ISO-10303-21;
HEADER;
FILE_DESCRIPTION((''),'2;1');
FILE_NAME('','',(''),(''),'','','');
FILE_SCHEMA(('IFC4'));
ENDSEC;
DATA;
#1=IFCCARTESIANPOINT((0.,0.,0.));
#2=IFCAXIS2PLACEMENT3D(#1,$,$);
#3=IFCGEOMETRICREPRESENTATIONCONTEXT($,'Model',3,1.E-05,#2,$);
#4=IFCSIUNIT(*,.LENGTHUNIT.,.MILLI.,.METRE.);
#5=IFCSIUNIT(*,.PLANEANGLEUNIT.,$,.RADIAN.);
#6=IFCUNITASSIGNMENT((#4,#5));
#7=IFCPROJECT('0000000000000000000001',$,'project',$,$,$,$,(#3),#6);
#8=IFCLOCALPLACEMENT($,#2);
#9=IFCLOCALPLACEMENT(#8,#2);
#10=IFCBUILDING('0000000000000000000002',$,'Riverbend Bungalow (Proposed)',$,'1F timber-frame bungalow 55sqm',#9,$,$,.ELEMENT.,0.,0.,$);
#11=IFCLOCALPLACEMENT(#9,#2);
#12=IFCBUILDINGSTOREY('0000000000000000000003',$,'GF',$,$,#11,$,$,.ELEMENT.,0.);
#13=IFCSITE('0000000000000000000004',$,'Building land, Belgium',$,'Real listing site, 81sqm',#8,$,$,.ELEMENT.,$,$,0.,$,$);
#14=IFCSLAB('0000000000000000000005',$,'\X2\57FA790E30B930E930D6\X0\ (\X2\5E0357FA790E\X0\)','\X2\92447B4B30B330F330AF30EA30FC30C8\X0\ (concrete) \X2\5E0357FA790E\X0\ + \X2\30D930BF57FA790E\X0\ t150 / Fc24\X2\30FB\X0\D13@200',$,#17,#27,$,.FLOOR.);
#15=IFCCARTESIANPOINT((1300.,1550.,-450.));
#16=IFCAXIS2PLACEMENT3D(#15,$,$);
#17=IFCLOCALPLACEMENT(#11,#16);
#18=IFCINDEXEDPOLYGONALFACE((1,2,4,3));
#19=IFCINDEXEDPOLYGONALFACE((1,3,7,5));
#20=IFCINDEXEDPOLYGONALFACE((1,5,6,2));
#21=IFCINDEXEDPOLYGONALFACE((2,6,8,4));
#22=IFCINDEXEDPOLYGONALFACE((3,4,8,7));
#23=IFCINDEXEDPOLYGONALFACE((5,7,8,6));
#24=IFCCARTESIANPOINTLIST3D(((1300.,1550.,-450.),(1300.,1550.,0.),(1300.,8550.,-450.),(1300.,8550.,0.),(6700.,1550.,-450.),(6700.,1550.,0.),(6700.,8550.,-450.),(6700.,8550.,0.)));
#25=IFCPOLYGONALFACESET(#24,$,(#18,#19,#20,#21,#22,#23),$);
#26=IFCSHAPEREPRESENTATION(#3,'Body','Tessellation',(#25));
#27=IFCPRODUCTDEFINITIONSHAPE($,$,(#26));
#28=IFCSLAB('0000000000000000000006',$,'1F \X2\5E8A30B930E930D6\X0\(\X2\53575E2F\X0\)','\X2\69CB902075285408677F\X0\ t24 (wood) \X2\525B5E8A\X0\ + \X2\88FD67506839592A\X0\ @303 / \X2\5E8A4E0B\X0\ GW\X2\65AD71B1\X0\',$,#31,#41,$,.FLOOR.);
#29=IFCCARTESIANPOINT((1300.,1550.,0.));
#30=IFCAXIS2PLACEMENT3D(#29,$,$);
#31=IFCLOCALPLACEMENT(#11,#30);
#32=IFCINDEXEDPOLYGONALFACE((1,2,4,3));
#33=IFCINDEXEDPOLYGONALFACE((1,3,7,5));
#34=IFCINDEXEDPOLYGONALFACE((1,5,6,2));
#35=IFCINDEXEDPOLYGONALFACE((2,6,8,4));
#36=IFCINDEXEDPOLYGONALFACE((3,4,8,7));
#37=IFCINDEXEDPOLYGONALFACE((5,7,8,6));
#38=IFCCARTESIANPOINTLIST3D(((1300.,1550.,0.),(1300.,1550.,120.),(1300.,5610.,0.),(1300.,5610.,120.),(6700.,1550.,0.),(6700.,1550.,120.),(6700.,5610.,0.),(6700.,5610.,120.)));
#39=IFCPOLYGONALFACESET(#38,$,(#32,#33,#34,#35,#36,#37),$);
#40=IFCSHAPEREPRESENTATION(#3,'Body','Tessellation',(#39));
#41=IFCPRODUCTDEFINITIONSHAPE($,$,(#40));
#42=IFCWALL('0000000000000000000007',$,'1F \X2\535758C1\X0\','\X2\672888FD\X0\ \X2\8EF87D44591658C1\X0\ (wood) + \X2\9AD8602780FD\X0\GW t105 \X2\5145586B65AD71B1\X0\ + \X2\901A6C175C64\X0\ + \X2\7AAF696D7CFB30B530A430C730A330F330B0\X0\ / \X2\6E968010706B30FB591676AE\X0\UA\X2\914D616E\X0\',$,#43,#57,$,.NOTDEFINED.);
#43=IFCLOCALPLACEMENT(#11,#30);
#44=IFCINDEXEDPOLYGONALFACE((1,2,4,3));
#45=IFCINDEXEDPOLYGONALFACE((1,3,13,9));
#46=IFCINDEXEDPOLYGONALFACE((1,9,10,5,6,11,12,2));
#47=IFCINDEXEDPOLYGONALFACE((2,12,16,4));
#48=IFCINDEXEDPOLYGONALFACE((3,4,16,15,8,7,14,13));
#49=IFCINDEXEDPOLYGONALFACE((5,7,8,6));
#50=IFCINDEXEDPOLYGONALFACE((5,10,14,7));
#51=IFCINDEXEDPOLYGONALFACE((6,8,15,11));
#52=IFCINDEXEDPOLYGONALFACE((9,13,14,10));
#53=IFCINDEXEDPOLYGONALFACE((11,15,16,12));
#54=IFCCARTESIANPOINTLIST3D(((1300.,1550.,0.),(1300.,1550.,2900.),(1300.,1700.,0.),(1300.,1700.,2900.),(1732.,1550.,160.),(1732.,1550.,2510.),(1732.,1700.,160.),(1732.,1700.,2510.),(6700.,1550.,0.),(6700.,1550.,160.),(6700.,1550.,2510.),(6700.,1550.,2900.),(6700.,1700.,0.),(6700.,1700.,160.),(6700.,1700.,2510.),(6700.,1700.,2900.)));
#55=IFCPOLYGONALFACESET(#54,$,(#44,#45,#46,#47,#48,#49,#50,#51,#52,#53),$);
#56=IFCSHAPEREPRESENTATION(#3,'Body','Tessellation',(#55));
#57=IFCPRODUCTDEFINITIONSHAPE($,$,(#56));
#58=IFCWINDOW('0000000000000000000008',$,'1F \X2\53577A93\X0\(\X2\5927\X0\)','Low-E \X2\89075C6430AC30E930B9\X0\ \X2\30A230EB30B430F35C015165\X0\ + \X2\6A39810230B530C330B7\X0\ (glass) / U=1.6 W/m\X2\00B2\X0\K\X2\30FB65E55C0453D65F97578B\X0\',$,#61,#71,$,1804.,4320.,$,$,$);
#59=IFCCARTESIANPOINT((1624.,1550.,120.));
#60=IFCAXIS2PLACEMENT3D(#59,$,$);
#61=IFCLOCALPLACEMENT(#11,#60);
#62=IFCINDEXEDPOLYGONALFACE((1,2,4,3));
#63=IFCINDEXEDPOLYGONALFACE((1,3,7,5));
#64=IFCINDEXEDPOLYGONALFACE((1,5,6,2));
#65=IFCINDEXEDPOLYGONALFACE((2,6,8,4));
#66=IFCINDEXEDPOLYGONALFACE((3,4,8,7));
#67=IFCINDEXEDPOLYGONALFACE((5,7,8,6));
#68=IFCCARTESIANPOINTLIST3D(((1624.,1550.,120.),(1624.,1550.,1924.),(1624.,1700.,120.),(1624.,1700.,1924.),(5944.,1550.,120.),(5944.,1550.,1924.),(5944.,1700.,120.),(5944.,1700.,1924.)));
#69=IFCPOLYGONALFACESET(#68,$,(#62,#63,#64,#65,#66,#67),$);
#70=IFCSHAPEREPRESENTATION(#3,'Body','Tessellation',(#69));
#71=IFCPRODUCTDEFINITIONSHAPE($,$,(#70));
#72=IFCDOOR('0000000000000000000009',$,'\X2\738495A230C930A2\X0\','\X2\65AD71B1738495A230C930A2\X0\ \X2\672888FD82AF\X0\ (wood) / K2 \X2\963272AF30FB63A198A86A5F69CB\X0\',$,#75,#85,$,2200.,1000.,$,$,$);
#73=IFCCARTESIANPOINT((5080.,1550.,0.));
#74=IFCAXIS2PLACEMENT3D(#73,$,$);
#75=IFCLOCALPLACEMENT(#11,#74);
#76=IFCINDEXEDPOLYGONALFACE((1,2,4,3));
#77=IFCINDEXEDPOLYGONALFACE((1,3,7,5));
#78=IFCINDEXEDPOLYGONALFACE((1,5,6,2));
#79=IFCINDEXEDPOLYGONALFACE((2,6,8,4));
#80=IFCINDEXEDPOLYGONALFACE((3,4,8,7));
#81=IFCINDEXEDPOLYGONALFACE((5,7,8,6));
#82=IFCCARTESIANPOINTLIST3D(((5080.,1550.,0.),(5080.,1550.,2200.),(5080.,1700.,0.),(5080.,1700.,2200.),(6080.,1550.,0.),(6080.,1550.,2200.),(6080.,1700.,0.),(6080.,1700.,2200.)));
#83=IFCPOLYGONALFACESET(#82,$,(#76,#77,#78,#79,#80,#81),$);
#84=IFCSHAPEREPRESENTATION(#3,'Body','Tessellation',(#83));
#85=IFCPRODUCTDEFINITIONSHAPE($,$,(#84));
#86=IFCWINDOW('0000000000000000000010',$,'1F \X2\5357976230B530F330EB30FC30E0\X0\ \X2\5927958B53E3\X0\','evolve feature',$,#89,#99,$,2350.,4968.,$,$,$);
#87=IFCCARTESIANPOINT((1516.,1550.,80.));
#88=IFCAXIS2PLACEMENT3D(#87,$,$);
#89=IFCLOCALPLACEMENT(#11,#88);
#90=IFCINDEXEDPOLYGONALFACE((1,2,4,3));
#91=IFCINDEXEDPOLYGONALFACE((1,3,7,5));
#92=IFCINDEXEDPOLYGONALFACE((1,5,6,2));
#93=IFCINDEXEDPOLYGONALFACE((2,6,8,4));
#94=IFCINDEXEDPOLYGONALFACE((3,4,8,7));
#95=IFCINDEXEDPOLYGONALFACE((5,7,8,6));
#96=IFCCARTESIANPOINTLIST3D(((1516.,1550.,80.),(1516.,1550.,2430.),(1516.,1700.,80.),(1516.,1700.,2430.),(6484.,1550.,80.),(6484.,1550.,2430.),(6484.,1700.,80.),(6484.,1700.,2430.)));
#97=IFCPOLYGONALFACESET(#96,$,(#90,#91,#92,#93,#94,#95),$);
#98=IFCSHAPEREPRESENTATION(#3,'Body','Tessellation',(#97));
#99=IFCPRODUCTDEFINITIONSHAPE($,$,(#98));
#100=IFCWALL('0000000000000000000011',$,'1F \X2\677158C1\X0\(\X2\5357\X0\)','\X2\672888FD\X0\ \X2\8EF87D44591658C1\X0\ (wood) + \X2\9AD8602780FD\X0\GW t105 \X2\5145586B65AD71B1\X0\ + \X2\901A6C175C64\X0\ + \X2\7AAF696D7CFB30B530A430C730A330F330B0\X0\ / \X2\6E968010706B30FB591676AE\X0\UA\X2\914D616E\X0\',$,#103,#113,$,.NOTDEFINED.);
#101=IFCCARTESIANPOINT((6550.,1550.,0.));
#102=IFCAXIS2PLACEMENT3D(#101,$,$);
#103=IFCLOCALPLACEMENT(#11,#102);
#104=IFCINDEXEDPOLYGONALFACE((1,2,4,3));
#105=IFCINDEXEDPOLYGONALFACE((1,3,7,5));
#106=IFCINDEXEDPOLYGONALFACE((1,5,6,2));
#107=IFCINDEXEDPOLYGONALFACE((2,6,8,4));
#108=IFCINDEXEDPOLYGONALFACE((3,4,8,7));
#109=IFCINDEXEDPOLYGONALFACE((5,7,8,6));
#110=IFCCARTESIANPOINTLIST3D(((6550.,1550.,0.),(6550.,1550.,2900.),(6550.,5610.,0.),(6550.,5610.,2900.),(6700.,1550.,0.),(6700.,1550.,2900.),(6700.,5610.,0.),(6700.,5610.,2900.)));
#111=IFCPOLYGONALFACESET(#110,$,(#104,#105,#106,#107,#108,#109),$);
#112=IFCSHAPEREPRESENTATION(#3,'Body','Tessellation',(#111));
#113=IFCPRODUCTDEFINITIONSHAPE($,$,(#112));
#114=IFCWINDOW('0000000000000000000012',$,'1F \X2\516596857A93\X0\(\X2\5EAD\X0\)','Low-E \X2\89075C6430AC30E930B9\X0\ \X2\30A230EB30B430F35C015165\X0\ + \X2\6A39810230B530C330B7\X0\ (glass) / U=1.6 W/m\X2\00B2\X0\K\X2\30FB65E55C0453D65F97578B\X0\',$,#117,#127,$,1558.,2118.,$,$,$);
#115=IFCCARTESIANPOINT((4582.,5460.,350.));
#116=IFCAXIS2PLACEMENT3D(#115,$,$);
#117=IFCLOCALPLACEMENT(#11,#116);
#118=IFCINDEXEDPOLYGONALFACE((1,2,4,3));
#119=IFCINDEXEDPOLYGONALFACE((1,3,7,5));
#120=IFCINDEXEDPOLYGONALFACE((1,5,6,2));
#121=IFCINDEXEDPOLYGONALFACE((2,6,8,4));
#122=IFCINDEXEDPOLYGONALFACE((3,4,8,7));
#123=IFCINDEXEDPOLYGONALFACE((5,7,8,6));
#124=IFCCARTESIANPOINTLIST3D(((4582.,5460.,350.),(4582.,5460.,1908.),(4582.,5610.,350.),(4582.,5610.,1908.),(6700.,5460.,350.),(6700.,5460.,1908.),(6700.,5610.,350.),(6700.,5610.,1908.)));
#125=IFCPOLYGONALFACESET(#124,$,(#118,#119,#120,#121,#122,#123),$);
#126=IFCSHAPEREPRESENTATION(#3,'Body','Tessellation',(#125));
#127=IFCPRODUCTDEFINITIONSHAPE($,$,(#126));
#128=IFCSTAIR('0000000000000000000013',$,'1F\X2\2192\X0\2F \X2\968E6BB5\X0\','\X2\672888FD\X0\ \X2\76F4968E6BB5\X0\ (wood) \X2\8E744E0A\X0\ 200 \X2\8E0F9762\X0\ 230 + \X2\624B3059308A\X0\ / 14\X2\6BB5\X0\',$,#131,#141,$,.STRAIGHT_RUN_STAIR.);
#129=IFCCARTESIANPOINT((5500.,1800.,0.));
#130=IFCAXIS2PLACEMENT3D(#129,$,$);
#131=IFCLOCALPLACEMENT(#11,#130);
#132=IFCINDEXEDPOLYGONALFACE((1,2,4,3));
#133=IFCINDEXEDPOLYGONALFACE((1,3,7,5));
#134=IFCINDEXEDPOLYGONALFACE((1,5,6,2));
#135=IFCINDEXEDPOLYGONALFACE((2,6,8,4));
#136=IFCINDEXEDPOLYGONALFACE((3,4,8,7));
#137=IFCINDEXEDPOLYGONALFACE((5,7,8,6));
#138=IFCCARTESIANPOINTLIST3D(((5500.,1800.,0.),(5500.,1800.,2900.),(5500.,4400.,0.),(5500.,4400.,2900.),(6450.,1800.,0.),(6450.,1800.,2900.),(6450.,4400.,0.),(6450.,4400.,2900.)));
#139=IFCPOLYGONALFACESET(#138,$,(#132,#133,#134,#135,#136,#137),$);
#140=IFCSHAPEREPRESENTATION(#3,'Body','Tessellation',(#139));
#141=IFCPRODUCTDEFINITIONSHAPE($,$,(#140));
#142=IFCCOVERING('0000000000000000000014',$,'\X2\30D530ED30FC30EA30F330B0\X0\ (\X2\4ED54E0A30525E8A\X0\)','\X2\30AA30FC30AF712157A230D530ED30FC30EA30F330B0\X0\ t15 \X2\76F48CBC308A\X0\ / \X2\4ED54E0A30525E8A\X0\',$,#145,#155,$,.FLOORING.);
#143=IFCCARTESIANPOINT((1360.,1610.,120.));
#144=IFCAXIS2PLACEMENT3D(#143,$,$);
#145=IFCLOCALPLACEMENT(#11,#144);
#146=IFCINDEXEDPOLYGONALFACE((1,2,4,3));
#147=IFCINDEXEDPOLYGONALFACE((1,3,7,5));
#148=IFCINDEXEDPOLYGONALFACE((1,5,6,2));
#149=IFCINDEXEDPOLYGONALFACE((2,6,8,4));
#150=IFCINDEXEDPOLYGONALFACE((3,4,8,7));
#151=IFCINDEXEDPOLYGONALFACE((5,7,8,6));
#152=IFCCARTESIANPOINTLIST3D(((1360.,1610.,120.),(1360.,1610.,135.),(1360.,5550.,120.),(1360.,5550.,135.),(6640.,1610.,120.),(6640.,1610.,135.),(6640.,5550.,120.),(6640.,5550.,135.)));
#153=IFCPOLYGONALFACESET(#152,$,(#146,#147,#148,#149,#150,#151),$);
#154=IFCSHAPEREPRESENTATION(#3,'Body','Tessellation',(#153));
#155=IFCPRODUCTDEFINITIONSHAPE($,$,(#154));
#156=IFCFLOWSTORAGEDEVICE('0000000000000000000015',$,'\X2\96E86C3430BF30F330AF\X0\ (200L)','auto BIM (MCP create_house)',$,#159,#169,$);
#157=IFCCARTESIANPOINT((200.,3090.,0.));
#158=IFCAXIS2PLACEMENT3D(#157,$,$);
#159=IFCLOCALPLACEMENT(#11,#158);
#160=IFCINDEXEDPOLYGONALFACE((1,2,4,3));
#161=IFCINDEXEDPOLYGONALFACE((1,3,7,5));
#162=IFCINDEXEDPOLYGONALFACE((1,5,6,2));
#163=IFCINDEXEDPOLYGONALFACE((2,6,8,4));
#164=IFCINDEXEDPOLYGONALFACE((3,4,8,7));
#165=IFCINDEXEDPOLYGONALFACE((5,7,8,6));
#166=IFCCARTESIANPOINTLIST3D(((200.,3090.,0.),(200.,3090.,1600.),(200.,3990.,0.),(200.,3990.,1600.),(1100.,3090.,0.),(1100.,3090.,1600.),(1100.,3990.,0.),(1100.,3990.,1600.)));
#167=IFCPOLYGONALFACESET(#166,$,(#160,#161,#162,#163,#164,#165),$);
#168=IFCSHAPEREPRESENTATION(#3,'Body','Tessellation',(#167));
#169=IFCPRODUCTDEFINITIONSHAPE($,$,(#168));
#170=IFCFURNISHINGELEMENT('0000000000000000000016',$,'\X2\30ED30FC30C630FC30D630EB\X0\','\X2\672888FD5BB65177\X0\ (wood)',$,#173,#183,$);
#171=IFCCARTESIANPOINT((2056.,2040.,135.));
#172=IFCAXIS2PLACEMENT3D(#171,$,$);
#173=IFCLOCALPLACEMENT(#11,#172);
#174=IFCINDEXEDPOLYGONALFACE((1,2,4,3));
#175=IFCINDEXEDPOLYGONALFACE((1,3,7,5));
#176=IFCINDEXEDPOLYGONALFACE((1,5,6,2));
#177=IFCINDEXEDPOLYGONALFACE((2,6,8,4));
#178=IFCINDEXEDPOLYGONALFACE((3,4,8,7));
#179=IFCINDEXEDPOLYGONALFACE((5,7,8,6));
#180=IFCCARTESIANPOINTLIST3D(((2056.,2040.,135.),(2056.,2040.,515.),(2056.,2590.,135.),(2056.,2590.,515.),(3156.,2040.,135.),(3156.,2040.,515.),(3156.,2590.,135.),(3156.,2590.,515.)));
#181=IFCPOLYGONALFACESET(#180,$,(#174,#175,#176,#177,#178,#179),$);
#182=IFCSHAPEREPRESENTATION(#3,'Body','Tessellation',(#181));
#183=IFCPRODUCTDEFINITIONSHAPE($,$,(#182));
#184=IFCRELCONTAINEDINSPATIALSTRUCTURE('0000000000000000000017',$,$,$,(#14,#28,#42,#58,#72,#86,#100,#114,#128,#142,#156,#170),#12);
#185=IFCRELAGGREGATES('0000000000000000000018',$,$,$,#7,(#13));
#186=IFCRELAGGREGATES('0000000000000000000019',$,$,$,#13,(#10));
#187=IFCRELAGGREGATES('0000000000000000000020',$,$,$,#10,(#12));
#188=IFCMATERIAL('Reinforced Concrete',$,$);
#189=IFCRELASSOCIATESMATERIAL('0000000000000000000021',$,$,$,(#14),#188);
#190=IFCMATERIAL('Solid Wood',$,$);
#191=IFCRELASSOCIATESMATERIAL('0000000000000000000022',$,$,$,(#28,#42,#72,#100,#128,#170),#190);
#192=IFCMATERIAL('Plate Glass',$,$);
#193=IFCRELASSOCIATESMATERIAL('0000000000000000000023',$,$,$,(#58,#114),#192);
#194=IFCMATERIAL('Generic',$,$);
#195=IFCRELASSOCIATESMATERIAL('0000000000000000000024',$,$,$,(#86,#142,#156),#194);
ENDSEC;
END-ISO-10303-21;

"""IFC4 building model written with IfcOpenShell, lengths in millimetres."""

from ifc_helpers import new_model, si_unit, frame, frame_2d, origin, place, context, project, spatial, rectangle, extrude, material, element, fill, save


model = new_model("IFC4")

# Units and contexts
model_context = context("Model", 3, precision=1e-05, world=origin())
ifc_project = project(units=[si_unit("LENGTHUNIT", "METRE", prefix="MILLI"), si_unit("PLANEANGLEUNIT", "RADIAN")], contexts=[model_context])

# Site, building, storey
site_placement = place(None, origin())
site = spatial("IfcSite", under=ifc_project, at=site_placement, Name="Building land, Belgium", ObjectType="Real listing site, 81sqm", CompositionType="ELEMENT", RefElevation=0.0)
building_placement = place(site_placement, origin())
building = spatial("IfcBuilding", under=site, at=building_placement, Name="Riverbend Bungalow (Proposed)", ObjectType="1F timber-frame bungalow 55sqm", CompositionType="ELEMENT", ElevationOfRefHeight=0.0, ElevationOfTerrain=0.0)
storey_placement = place(building_placement, origin())
storey = spatial("IfcBuildingStorey", under=building, at=storey_placement, Name="GF", CompositionType="ELEMENT", Elevation=0.0)

# Slabs
ifc_material_1 = material(Name="Reinforced Concrete")
slab_1_placement = place(storey_placement, frame((1300.0, 1550.0, -450.0)))
element("IfcSlab", 1, at=slab_1_placement, inside=storey, material=ifc_material_1, Name="基礎スラブ (布基礎)", Description="鉄筋コンクリート (concrete) 布基礎 + ベタ基礎 t150 / Fc24・D13@200", PredefinedType="FLOOR", context=model_context, shape_type="SweptSolid", body=[
    extrude(rectangle(XDim=5400.0, YDim=7000.0, at=frame_2d((2700.0, 3500.0))), frame((1300.0, 1550.0, -450.0)), (0.0, 0.0, 1.0), 450.0),
])
ifc_material_2 = material(Name="Solid Wood")
slab_2_placement = place(storey_placement, frame((1300.0, 1550.0, 0.0)))
element("IfcSlab", 2, at=slab_2_placement, inside=storey, material=ifc_material_2, Name="1F 床スラブ(南帯)", Description="構造用合板 t24 (wood) 剛床 + 製材根太 @303 / 床下 GW断熱", PredefinedType="FLOOR", context=model_context, shape_type="SweptSolid", body=[
    extrude(rectangle(XDim=5400.0, YDim=4060.0, at=frame_2d((2700.0, 2030.0))), frame((1300.0, 1550.0, 0.0)), (0.0, 0.0, 1.0), 120.0),
])

# Wall, openings, windows, door
wall_1_placement = place(storey_placement, frame((1300.0, 1550.0, 0.0)))
wall_1 = element("IfcWall", 3, at=wall_1_placement, inside=storey, material=ifc_material_2, Name="1F 南壁", Description="木製 軸組外壁 (wood) + 高性能GW t105 充填断熱 + 通気層 + 窯業系サイディング / 準耐火・外皮UA配慮", PredefinedType="NOTDEFINED", context=model_context, shape_type="SweptSolid", body=[
    extrude(rectangle(XDim=5400.0, YDim=150.0, at=frame_2d((2700.0, 75.0))), frame((1300.0, 1550.0, 0.0)), (0.0, 0.0, 1.0), 2900.0),
])
opening_1_placement = place(storey_placement, frame((1624.0, 1550.0, 120.0)))
opening_1 = element("IfcOpeningElement", 4, at=opening_1_placement, cuts=wall_1, PredefinedType="NOTDEFINED", context=model_context, shape_type="SweptSolid", body=[
    extrude(rectangle(XDim=4320.0, YDim=150.0, at=frame_2d((2160.0, 75.0))), frame((1624.0, 1550.0, 120.0)), (0.0, 0.0, 1.0), 1804.0),
])
opening_2_placement = place(storey_placement, frame((5080.0, 1550.0, 0.0)))
opening_2 = element("IfcOpeningElement", 5, at=opening_2_placement, cuts=wall_1, PredefinedType="NOTDEFINED", context=model_context, shape_type="SweptSolid", body=[
    extrude(rectangle(XDim=1000.0, YDim=150.0, at=frame_2d((500.0, 75.0))), frame((5080.0, 1550.0, 0.0)), (0.0, 0.0, 1.0), 2200.0),
])
opening_3_placement = place(storey_placement, frame((1516.0, 1550.0, 80.0)))
opening_3 = element("IfcOpeningElement", 6, at=opening_3_placement, cuts=wall_1, PredefinedType="NOTDEFINED", context=model_context, shape_type="SweptSolid", body=[
    extrude(rectangle(XDim=4968.0, YDim=150.0, at=frame_2d((2484.0, 75.0))), frame((1516.0, 1550.0, 80.0)), (0.0, 0.0, 1.0), 2350.0),
])
ifc_material_3 = material(Name="Plate Glass")
window_1_placement = place(storey_placement, frame((1624.0, 1550.0, 120.0)))
window_1 = element("IfcWindow", 7, at=window_1_placement, inside=storey, material=ifc_material_3, Name="1F 南窓(大)", Description="Low-E 複層ガラス アルゴン封入 + 樹脂サッシ (glass) / U=1.6 W/m²K・日射取得型", OverallHeight=1804.0, OverallWidth=4320.0, context=model_context, shape_type="SweptSolid", body=[
    extrude(rectangle(XDim=4320.0, YDim=150.0, at=frame_2d((2160.0, 75.0))), frame((1624.0, 1550.0, 120.0)), (0.0, 0.0, 1.0), 1804.0),
])
fill(opening_1, window_1)
door_1_placement = place(storey_placement, frame((5080.0, 1550.0, 0.0)))
door_1 = element("IfcDoor", 8, at=door_1_placement, inside=storey, material=ifc_material_2, Name="玄関ドア", Description="断熱玄関ドア 木製芯 (wood) / K2 防犯・採風機構", OverallHeight=2200.0, OverallWidth=1000.0, context=model_context, shape_type="SweptSolid", body=[
    extrude(rectangle(XDim=1000.0, YDim=150.0, at=frame_2d((500.0, 75.0))), frame((5080.0, 1550.0, 0.0)), (0.0, 0.0, 1.0), 2200.0),
])
fill(opening_2, door_1)
ifc_material_4 = material(Name="Generic")
window_2_placement = place(storey_placement, frame((1516.0, 1550.0, 80.0)))
window_2 = element("IfcWindow", 9, at=window_2_placement, inside=storey, material=ifc_material_4, Name="1F 南面サンルーム 大開口", Description="evolve feature", OverallHeight=2350.0, OverallWidth=4968.0, context=model_context, shape_type="SweptSolid", body=[
    extrude(rectangle(XDim=4968.0, YDim=150.0, at=frame_2d((2484.0, 75.0))), frame((1516.0, 1550.0, 80.0)), (0.0, 0.0, 1.0), 2350.0),
])
fill(opening_3, window_2)

# Wall, opening, window
wall_2_placement = place(storey_placement, frame((6550.0, 1550.0, 0.0)))
wall_2 = element("IfcWall", 10, at=wall_2_placement, inside=storey, material=ifc_material_2, Name="1F 東壁(南)", Description="木製 軸組外壁 (wood) + 高性能GW t105 充填断熱 + 通気層 + 窯業系サイディング / 準耐火・外皮UA配慮", PredefinedType="NOTDEFINED", context=model_context, shape_type="SweptSolid", body=[
    extrude(rectangle(XDim=150.0, YDim=4060.0, at=frame_2d((75.0, 2030.0))), frame((6550.0, 1550.0, 0.0)), (0.0, 0.0, 1.0), 2900.0),
])
opening_4_placement = place(storey_placement, frame((4582.0, 5460.0, 350.0)))
opening_4 = element("IfcOpeningElement", 11, at=opening_4_placement, cuts=wall_2, PredefinedType="NOTDEFINED", context=model_context, shape_type="SweptSolid", body=[
    extrude(rectangle(XDim=2118.0, YDim=150.0, at=frame_2d((1059.0, 75.0))), frame((4582.0, 5460.0, 350.0)), (0.0, 0.0, 1.0), 1558.0),
])
window_3_placement = place(storey_placement, frame((4582.0, 5460.0, 350.0)))
window_3 = element("IfcWindow", 12, at=window_3_placement, inside=storey, material=ifc_material_3, Name="1F 入隅窓(庭)", Description="Low-E 複層ガラス アルゴン封入 + 樹脂サッシ (glass) / U=1.6 W/m²K・日射取得型", OverallHeight=1558.0, OverallWidth=2118.0, context=model_context, shape_type="SweptSolid", body=[
    extrude(rectangle(XDim=2118.0, YDim=150.0, at=frame_2d((1059.0, 75.0))), frame((4582.0, 5460.0, 350.0)), (0.0, 0.0, 1.0), 1558.0),
])
fill(opening_4, window_3)

# Stair
stair_placement = place(storey_placement, frame((5500.0, 1800.0, 0.0)))
element("IfcStair", 13, at=stair_placement, inside=storey, material=ifc_material_2, Name="1F→2F 階段", Description="木製 直階段 (wood) 蹴上 200 踏面 230 + 手すり / 14段", PredefinedType="STRAIGHT_RUN_STAIR", context=model_context, shape_type="SweptSolid", body=[
    extrude(rectangle(XDim=950.0, YDim=2600.0, at=frame_2d((475.0, 1300.0))), frame((5500.0, 1800.0, 0.0)), (0.0, 0.0, 1.0), 2900.0),
])

# Covering
covering_placement = place(storey_placement, frame((1360.0, 1610.0, 120.0)))
element("IfcCovering", 14, at=covering_placement, inside=storey, material=ifc_material_4, Name="フローリング (仕上げ床)", Description="オーク無垢フローリング t15 直貼り / 仕上げ床", PredefinedType="FLOORING", context=model_context, shape_type="SweptSolid", body=[
    extrude(rectangle(XDim=5280.0, YDim=3940.0, at=frame_2d((2640.0, 1970.0))), frame((1360.0, 1610.0, 120.0)), (0.0, 0.0, 1.0), 15.0),
])

# Flow storage device
flow_storage_device_placement = place(storey_placement, frame((200.0, 3090.0, 0.0)))
element("IfcFlowStorageDevice", 15, at=flow_storage_device_placement, inside=storey, material=ifc_material_4, Name="雨水タンク (200L)", Description="auto BIM (MCP create_house)", context=model_context, shape_type="SweptSolid", body=[
    extrude(rectangle(XDim=900.0, YDim=900.0, at=frame_2d((450.0, 450.0))), frame((200.0, 3090.0, 0.0)), (0.0, 0.0, 1.0), 1600.0),
])

# Furnishing element
furnishing_1_placement = place(storey_placement, frame((2056.0, 2040.0, 135.0)))
element("IfcFurnishingElement", 16, at=furnishing_1_placement, inside=storey, material=ifc_material_2, Name="ローテーブル", Description="木製家具 (wood)", context=model_context, shape_type="SweptSolid", body=[
    extrude(rectangle(XDim=1100.0, YDim=550.0, at=frame_2d((550.0, 275.0))), frame((2056.0, 2040.0, 135.0)), (0.0, 0.0, 1.0), 380.0),
])

save(model, "model.ifc")
